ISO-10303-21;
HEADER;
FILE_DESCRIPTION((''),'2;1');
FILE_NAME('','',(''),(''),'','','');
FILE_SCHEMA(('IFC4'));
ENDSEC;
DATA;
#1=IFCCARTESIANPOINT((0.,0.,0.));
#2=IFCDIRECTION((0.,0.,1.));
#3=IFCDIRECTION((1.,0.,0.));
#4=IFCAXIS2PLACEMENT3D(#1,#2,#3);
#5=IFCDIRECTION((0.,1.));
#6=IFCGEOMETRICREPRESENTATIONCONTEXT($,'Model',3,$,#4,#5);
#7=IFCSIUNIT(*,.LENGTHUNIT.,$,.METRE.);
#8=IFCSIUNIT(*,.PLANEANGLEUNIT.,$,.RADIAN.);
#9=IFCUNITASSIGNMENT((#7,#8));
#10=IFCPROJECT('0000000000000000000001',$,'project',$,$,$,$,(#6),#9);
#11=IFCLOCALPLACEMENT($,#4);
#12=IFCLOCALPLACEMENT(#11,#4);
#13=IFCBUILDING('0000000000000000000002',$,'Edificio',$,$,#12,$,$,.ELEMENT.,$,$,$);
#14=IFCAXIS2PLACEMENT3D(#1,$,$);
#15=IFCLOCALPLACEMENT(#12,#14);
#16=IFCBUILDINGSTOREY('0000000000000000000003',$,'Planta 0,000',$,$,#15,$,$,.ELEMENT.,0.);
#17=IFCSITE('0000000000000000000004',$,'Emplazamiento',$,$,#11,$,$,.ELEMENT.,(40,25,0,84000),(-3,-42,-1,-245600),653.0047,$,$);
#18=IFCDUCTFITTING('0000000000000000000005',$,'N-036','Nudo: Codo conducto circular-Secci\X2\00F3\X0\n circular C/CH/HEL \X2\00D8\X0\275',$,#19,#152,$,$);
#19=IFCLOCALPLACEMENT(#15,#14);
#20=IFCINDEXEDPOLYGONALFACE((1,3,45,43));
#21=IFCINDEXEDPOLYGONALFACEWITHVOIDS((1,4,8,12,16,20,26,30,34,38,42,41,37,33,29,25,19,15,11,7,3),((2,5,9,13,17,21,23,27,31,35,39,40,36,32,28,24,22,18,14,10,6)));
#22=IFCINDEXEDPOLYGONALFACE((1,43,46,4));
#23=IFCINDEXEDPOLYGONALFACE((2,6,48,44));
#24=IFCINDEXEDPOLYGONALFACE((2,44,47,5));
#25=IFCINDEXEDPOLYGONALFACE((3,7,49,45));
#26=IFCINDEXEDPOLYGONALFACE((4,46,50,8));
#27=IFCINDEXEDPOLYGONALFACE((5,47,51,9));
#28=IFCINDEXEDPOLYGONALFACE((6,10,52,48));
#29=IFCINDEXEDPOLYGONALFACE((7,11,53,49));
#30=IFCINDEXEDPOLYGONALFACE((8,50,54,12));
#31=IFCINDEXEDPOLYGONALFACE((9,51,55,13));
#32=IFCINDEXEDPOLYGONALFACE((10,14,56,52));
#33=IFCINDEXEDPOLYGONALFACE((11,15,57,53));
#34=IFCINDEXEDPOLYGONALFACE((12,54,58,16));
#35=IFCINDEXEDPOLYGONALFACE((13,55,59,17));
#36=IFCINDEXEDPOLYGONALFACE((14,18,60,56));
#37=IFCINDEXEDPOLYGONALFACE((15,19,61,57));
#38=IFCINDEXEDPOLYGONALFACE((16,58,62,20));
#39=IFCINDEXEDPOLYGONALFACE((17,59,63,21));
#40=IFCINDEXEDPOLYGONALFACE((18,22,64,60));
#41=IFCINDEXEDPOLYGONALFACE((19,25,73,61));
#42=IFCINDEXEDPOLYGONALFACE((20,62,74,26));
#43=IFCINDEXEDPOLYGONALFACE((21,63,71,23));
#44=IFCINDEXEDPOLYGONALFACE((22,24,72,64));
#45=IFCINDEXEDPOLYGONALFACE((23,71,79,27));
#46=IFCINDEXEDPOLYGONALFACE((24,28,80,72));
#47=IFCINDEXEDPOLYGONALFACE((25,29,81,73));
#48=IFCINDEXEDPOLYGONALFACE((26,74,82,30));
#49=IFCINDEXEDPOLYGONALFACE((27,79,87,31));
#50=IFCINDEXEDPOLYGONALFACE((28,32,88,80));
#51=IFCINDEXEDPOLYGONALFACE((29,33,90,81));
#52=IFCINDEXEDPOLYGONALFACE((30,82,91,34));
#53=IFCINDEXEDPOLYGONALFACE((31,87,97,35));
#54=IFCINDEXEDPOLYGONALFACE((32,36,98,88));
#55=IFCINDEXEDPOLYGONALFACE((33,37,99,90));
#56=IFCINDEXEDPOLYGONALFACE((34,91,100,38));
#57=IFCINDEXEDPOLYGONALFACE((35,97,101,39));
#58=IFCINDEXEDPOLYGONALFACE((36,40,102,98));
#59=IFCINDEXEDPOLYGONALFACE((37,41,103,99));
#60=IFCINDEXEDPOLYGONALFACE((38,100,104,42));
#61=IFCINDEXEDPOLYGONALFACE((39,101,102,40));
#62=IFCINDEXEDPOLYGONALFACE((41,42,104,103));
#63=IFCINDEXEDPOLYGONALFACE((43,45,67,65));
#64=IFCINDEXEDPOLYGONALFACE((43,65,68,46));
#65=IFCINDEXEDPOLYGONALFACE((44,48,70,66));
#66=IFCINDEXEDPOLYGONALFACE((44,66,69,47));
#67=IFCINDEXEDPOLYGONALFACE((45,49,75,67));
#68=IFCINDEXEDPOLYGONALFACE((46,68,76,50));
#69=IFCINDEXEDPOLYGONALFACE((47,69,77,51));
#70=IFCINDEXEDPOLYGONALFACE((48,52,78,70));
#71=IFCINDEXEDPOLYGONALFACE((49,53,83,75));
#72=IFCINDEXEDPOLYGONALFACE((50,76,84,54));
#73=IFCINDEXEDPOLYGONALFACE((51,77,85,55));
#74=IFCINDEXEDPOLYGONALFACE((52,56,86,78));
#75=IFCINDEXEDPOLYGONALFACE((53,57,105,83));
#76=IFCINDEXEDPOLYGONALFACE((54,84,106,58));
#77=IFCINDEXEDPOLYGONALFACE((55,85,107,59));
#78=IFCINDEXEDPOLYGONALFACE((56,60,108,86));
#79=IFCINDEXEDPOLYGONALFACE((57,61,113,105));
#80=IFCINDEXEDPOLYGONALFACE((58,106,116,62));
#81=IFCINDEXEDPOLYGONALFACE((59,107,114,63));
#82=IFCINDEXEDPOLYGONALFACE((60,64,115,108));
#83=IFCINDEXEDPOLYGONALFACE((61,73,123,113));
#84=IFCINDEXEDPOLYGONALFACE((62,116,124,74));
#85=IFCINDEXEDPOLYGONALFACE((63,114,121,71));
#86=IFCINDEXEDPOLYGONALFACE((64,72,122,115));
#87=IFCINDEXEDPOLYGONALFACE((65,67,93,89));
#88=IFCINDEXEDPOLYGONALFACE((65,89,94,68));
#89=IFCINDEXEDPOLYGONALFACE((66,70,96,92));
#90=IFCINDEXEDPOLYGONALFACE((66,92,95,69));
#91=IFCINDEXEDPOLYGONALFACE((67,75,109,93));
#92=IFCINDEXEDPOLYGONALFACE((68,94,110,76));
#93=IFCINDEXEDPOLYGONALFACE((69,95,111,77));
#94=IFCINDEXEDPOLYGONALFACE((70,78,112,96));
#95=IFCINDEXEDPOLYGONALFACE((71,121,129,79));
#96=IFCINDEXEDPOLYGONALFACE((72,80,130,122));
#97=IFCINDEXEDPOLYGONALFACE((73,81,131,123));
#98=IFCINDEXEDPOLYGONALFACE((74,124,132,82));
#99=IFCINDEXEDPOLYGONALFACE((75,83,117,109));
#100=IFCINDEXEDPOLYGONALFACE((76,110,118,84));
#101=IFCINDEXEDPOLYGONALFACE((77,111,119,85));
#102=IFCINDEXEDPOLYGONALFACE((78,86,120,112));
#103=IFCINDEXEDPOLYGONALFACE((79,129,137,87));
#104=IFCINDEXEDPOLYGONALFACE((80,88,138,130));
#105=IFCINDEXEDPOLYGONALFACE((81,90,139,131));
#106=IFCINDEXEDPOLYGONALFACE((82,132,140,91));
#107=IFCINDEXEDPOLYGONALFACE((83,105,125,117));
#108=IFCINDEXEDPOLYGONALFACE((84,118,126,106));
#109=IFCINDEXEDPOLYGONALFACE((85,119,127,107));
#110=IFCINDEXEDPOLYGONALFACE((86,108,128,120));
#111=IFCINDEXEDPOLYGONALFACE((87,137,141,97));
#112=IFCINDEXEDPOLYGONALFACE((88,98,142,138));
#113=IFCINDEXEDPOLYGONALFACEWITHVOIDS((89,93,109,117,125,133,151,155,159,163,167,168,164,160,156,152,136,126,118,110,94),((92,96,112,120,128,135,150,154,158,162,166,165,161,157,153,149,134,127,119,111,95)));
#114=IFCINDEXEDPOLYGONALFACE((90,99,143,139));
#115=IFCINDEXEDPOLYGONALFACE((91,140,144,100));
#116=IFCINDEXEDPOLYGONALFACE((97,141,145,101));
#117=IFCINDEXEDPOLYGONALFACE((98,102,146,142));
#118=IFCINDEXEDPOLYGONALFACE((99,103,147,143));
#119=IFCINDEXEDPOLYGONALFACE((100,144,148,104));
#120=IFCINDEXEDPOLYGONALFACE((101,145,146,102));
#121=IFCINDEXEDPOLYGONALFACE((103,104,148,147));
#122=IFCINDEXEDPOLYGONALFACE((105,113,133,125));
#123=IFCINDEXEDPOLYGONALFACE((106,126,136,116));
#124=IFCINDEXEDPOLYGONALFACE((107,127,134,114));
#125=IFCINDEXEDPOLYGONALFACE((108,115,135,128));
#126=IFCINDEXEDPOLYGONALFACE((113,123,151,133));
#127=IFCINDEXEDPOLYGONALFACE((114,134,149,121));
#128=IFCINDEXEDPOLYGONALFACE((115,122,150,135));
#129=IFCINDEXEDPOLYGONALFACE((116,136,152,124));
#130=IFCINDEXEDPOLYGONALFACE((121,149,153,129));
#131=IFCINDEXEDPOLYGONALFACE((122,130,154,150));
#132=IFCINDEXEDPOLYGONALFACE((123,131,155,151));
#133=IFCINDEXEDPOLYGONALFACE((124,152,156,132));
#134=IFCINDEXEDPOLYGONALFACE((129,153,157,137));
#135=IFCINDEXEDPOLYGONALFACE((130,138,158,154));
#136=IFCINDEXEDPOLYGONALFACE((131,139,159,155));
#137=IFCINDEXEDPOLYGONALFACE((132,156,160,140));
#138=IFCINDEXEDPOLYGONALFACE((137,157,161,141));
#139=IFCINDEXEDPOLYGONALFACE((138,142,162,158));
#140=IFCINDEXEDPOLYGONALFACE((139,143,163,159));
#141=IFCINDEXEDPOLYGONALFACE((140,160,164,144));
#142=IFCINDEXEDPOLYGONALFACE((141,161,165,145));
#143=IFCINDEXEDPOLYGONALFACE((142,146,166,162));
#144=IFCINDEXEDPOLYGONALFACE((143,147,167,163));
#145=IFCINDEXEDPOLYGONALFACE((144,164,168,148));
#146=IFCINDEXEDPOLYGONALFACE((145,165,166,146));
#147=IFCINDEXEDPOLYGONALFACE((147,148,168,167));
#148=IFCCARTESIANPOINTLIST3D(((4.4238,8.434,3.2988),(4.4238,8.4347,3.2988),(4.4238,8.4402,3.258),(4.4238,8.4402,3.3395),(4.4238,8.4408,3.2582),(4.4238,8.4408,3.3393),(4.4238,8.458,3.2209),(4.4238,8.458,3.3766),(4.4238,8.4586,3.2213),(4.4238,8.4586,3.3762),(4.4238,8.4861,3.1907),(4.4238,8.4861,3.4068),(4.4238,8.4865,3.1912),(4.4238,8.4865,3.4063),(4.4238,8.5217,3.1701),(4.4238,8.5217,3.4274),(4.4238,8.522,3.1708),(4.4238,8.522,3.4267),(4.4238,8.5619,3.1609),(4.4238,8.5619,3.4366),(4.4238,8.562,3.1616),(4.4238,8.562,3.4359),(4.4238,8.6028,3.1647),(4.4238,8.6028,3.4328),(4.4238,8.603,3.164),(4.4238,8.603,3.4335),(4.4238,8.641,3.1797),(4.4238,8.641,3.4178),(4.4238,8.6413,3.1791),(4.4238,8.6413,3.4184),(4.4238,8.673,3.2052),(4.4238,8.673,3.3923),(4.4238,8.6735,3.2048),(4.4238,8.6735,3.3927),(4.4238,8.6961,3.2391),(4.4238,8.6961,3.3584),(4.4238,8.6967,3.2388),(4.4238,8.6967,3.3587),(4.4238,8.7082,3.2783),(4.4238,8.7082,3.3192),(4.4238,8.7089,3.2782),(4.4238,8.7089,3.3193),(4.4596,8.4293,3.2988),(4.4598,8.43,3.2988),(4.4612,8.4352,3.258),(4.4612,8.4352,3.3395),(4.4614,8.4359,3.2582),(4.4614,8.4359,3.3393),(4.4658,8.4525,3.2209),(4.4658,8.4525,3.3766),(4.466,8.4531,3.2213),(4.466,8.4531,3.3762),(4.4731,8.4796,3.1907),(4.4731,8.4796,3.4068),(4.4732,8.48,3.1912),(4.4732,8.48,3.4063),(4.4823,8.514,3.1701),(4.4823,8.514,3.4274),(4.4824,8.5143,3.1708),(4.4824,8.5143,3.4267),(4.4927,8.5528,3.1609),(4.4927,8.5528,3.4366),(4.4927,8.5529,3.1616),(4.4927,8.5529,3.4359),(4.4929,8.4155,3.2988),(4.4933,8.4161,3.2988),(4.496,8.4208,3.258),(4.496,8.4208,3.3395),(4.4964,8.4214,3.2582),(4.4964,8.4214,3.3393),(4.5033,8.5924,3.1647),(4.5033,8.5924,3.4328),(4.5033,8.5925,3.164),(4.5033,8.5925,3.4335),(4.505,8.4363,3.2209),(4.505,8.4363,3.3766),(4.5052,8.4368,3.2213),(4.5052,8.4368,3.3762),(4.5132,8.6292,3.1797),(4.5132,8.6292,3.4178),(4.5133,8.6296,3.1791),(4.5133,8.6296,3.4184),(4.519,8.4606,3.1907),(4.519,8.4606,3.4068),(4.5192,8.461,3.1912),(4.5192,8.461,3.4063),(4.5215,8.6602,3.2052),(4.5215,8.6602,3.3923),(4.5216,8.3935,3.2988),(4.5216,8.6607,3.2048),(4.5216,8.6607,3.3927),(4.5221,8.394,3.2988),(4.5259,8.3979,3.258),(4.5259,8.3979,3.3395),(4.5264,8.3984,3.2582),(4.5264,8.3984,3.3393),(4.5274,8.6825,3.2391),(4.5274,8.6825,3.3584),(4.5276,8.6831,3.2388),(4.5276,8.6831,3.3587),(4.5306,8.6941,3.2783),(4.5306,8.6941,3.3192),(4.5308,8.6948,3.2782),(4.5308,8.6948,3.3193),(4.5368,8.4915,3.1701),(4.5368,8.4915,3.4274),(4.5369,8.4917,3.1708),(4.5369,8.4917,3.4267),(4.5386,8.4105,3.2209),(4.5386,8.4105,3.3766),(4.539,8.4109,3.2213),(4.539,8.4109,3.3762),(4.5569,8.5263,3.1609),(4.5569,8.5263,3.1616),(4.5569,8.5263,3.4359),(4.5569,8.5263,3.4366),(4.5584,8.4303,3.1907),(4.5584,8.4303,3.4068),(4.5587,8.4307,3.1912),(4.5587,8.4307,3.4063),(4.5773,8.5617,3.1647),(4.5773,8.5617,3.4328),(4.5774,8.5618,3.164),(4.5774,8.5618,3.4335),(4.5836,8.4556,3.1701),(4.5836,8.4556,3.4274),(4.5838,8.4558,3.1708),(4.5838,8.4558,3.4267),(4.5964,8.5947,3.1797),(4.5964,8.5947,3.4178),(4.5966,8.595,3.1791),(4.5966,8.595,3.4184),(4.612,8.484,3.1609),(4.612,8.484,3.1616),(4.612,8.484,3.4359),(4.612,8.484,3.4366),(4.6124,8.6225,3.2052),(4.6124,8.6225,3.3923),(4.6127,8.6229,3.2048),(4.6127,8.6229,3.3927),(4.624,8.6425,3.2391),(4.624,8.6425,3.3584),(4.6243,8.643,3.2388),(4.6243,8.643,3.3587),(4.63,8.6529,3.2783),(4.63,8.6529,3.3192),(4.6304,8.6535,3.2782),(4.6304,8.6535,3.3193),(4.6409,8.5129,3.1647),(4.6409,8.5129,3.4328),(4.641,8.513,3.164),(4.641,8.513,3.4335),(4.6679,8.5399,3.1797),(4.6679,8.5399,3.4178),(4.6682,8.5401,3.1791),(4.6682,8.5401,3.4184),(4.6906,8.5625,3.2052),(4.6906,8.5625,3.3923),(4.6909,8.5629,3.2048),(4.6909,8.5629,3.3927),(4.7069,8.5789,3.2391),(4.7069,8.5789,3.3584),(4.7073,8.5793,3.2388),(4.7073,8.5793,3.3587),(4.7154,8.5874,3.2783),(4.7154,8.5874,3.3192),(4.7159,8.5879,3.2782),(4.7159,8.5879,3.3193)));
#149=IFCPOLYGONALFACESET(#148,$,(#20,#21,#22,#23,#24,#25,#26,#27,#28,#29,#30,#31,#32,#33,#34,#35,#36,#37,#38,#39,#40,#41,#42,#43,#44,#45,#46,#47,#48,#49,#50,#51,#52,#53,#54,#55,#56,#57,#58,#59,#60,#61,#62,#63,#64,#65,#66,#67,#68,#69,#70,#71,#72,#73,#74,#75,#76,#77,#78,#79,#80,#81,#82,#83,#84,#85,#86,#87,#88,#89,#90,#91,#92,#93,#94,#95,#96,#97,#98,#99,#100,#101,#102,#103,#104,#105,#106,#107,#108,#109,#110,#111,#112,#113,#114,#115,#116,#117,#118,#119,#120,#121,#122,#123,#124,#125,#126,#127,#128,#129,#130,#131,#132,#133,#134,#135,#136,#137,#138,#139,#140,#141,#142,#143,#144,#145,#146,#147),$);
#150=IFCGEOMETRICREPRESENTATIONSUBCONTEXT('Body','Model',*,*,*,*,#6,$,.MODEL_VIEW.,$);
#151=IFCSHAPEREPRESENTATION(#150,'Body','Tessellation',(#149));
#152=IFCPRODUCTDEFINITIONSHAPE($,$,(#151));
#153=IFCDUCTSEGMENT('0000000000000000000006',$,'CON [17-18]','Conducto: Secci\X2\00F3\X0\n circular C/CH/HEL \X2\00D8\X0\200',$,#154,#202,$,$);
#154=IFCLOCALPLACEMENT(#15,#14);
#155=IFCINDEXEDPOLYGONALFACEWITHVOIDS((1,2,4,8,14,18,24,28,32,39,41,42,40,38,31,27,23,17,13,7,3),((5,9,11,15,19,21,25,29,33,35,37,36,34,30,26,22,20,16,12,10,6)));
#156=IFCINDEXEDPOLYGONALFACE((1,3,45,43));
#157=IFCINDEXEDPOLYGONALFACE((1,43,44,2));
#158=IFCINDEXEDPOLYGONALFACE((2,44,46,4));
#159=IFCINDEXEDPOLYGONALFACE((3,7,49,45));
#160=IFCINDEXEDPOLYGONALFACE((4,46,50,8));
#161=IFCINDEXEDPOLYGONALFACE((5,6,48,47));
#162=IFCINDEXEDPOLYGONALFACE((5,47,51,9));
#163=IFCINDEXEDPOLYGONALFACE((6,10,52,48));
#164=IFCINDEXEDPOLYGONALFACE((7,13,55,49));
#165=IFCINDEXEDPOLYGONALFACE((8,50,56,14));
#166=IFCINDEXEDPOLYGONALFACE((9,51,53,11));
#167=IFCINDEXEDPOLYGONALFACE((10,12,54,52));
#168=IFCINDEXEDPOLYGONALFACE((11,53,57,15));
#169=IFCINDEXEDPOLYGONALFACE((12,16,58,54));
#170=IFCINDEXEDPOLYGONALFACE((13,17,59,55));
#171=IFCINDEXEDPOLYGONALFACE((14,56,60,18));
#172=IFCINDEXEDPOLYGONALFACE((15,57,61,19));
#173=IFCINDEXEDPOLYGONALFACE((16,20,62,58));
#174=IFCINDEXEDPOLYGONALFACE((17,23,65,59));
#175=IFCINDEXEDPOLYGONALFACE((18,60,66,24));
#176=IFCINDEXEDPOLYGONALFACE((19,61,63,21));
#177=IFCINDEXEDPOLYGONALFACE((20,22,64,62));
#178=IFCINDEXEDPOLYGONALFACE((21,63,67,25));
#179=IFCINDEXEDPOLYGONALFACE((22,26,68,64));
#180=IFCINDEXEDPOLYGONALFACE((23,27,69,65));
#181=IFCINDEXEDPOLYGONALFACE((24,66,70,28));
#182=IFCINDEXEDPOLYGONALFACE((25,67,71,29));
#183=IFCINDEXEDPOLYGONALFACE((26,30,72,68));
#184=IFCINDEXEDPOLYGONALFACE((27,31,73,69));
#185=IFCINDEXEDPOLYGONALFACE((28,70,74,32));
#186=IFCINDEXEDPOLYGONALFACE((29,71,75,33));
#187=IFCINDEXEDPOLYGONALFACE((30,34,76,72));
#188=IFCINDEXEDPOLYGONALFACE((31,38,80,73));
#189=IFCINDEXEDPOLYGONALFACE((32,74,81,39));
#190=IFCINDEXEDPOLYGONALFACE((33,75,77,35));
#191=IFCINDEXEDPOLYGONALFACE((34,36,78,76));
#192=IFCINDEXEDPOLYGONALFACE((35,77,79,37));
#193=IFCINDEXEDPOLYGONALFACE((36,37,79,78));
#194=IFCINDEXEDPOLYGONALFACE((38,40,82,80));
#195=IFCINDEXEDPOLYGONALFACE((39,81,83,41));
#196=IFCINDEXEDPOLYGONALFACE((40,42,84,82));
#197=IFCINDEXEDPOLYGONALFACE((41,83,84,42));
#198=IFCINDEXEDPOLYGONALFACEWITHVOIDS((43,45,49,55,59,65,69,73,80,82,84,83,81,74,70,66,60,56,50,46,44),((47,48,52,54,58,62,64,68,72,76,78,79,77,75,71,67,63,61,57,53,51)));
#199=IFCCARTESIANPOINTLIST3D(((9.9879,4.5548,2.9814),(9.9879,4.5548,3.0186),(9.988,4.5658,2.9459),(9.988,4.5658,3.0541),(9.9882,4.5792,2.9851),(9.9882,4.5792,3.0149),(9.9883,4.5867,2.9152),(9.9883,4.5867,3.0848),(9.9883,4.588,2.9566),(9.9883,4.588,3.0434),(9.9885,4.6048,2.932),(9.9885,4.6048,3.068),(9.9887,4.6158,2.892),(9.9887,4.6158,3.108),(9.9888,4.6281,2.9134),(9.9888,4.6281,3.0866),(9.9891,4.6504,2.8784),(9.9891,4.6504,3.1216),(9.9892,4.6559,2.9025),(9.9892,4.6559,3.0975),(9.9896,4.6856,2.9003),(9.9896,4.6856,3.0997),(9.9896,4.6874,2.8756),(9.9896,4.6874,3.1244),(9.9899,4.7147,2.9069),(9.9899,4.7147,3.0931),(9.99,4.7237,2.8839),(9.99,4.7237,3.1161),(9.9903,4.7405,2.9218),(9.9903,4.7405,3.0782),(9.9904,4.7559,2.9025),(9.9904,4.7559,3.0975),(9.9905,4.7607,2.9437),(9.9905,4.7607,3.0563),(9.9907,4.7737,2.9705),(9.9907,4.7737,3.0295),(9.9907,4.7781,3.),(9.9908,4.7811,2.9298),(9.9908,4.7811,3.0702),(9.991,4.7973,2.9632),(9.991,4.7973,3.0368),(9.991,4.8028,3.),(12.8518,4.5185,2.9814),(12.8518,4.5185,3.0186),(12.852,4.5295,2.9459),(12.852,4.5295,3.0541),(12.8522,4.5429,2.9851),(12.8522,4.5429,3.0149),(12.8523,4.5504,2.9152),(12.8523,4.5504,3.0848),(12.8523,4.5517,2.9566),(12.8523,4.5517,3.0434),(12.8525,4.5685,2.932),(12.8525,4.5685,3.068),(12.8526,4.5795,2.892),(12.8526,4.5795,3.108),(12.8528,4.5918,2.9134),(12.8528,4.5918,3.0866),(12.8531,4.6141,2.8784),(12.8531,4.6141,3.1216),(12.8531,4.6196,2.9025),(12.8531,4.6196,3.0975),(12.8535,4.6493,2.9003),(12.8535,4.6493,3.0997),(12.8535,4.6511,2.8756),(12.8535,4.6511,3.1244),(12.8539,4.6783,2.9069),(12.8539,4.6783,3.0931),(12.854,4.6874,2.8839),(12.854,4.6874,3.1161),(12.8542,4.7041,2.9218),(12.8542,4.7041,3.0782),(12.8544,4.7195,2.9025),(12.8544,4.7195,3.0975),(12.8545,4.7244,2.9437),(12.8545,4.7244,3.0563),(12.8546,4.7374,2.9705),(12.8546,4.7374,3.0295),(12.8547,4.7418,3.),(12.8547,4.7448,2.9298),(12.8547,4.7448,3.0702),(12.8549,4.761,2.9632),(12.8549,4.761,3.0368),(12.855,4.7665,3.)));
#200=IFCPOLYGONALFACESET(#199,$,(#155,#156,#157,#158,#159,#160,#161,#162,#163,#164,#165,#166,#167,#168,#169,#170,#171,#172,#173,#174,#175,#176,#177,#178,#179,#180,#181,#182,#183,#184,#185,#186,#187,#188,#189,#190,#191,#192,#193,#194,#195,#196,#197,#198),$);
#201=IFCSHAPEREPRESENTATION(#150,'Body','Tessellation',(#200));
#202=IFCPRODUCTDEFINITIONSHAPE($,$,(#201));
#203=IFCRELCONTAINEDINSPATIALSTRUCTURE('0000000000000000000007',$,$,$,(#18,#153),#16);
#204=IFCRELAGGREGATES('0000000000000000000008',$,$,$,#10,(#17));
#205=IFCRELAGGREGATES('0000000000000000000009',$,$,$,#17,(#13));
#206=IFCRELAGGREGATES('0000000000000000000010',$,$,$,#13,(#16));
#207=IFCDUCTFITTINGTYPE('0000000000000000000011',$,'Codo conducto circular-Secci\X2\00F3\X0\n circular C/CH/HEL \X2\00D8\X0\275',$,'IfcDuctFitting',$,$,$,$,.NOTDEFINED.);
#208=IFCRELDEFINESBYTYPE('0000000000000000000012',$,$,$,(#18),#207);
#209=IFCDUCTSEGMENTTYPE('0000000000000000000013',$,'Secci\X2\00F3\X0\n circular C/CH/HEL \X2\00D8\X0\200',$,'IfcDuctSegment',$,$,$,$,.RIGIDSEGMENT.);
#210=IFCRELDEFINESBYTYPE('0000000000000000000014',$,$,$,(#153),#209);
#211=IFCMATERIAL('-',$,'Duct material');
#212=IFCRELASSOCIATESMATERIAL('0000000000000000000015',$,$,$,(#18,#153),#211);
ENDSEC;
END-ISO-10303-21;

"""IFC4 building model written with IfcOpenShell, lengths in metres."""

from ifc_helpers import new_model, entity, si_unit, direction, frame, origin, origin_with_axes, origin_2d_with_axis, place, context, subcontext, project, spatial, hollow_circle, extrude, source, transform, mapped, material, type_object, element, save


model = new_model("IFC4")

# Units and contexts
model_context = context("Model", 3, world=origin_with_axes(), true_north=direction((0.0, 1.0)))
body_context = subcontext(model_context, "Body", "Model", "MODEL_VIEW")
ifc_project = project(units=[si_unit("LENGTHUNIT", "METRE"), si_unit("PLANEANGLEUNIT", "RADIAN")], contexts=[model_context])

# Site, building, storey
site_placement = place(None, origin_with_axes())
site = spatial("IfcSite", under=ifc_project, at=site_placement, Name="Emplazamiento", CompositionType="ELEMENT", RefLatitude=(40, 25, 0, 84000), RefLongitude=(-3, -42, -1, -245600), RefElevation=653.0047)
building_placement = place(site_placement, origin_with_axes())
building = spatial("IfcBuilding", under=site, at=building_placement, Name="Edificio", CompositionType="ELEMENT")
storey_placement = place(building_placement, origin())
storey = spatial("IfcBuildingStorey", under=building, at=storey_placement, Name="Planta 0,000", CompositionType="ELEMENT", Elevation=0.0)

# Shared definitions
ifc_material_1 = material(Name="-", Category="Duct material")

# Duct fitting
duct_fitting_type_1 = type_object("IfcDuctFittingType", Name="Codo conducto circular-Sección circular C/CH/HEL Ø275", ApplicableOccurrence="IfcDuctFitting", PredefinedType="NOTDEFINED")
shared_shape_1 = source(origin_with_axes(), body_context, "Body", "SweptSolid", [
    entity("IfcRevolvedAreaSolid", entity("IfcCircleHollowProfileDef", "AREA", None, entity("IfcAxis2Placement2D", entity("IfcCartesianPoint", [0.0, 0.0]), entity("IfcDirection", [1.0, 0.0])), 0.1382, 0.0007), entity("IfcAxis2Placement3D", entity("IfcCartesianPoint", [0.081, 0.081, 0.0]), entity("IfcDirection", [-0.707107, -0.707107, 0.0]), entity("IfcDirection", [0.707107, -0.707107, 0.0])), entity("IfcAxis1Placement", entity("IfcCartesianPoint", [0.2764, 0.0, 0.0]), entity("IfcDirection", [0.0, 1.0, 0.0])), 0.785398),
])
duct_fitting_1_placement = place(storey_placement, origin_with_axes())
element("IfcDuctFitting", 1, at=duct_fitting_1_placement, inside=storey, type_object=duct_fitting_type_1, material=ifc_material_1, Name="N-036", Description="Nudo: Codo conducto circular-Sección circular C/CH/HEL Ø275", context=body_context, shape_type="MappedRepresentation", body=[
    mapped(shared_shape_1, transform((4.5383, 8.5722, 3.2988), x_axis=(0.0, -1.0, 0.0), y_axis=(1.0, 0.0, 0.0), z_axis=(0.0, 0.0, 1.0), scale=1.0)),
])

# Duct segment
duct_segment_type_1 = type_object("IfcDuctSegmentType", Name="Sección circular C/CH/HEL Ø200", ApplicableOccurrence="IfcDuctSegment", PredefinedType="RIGIDSEGMENT")
duct_segment_1_placement = place(storey_placement, origin_with_axes())
element("IfcDuctSegment", 2, at=duct_segment_1_placement, inside=storey, type_object=duct_segment_type_1, material=ifc_material_1, Name="CON [17-18]", Description="Conducto: Sección circular C/CH/HEL Ø200", context=body_context, shape_type="SweptSolid", body=[
    extrude(hollow_circle(Radius=0.1247, WallThickness=0.0247, at=origin_2d_with_axis()), frame((9.9895, 4.6781, 3.0), z_axis=(0.99992, -0.01268, 0.0), x_axis=(0.01268, 0.99992, 0.0)), (0.0, 0.0, 1.0), 2.8642),
])

save(model, "model.ifc")
